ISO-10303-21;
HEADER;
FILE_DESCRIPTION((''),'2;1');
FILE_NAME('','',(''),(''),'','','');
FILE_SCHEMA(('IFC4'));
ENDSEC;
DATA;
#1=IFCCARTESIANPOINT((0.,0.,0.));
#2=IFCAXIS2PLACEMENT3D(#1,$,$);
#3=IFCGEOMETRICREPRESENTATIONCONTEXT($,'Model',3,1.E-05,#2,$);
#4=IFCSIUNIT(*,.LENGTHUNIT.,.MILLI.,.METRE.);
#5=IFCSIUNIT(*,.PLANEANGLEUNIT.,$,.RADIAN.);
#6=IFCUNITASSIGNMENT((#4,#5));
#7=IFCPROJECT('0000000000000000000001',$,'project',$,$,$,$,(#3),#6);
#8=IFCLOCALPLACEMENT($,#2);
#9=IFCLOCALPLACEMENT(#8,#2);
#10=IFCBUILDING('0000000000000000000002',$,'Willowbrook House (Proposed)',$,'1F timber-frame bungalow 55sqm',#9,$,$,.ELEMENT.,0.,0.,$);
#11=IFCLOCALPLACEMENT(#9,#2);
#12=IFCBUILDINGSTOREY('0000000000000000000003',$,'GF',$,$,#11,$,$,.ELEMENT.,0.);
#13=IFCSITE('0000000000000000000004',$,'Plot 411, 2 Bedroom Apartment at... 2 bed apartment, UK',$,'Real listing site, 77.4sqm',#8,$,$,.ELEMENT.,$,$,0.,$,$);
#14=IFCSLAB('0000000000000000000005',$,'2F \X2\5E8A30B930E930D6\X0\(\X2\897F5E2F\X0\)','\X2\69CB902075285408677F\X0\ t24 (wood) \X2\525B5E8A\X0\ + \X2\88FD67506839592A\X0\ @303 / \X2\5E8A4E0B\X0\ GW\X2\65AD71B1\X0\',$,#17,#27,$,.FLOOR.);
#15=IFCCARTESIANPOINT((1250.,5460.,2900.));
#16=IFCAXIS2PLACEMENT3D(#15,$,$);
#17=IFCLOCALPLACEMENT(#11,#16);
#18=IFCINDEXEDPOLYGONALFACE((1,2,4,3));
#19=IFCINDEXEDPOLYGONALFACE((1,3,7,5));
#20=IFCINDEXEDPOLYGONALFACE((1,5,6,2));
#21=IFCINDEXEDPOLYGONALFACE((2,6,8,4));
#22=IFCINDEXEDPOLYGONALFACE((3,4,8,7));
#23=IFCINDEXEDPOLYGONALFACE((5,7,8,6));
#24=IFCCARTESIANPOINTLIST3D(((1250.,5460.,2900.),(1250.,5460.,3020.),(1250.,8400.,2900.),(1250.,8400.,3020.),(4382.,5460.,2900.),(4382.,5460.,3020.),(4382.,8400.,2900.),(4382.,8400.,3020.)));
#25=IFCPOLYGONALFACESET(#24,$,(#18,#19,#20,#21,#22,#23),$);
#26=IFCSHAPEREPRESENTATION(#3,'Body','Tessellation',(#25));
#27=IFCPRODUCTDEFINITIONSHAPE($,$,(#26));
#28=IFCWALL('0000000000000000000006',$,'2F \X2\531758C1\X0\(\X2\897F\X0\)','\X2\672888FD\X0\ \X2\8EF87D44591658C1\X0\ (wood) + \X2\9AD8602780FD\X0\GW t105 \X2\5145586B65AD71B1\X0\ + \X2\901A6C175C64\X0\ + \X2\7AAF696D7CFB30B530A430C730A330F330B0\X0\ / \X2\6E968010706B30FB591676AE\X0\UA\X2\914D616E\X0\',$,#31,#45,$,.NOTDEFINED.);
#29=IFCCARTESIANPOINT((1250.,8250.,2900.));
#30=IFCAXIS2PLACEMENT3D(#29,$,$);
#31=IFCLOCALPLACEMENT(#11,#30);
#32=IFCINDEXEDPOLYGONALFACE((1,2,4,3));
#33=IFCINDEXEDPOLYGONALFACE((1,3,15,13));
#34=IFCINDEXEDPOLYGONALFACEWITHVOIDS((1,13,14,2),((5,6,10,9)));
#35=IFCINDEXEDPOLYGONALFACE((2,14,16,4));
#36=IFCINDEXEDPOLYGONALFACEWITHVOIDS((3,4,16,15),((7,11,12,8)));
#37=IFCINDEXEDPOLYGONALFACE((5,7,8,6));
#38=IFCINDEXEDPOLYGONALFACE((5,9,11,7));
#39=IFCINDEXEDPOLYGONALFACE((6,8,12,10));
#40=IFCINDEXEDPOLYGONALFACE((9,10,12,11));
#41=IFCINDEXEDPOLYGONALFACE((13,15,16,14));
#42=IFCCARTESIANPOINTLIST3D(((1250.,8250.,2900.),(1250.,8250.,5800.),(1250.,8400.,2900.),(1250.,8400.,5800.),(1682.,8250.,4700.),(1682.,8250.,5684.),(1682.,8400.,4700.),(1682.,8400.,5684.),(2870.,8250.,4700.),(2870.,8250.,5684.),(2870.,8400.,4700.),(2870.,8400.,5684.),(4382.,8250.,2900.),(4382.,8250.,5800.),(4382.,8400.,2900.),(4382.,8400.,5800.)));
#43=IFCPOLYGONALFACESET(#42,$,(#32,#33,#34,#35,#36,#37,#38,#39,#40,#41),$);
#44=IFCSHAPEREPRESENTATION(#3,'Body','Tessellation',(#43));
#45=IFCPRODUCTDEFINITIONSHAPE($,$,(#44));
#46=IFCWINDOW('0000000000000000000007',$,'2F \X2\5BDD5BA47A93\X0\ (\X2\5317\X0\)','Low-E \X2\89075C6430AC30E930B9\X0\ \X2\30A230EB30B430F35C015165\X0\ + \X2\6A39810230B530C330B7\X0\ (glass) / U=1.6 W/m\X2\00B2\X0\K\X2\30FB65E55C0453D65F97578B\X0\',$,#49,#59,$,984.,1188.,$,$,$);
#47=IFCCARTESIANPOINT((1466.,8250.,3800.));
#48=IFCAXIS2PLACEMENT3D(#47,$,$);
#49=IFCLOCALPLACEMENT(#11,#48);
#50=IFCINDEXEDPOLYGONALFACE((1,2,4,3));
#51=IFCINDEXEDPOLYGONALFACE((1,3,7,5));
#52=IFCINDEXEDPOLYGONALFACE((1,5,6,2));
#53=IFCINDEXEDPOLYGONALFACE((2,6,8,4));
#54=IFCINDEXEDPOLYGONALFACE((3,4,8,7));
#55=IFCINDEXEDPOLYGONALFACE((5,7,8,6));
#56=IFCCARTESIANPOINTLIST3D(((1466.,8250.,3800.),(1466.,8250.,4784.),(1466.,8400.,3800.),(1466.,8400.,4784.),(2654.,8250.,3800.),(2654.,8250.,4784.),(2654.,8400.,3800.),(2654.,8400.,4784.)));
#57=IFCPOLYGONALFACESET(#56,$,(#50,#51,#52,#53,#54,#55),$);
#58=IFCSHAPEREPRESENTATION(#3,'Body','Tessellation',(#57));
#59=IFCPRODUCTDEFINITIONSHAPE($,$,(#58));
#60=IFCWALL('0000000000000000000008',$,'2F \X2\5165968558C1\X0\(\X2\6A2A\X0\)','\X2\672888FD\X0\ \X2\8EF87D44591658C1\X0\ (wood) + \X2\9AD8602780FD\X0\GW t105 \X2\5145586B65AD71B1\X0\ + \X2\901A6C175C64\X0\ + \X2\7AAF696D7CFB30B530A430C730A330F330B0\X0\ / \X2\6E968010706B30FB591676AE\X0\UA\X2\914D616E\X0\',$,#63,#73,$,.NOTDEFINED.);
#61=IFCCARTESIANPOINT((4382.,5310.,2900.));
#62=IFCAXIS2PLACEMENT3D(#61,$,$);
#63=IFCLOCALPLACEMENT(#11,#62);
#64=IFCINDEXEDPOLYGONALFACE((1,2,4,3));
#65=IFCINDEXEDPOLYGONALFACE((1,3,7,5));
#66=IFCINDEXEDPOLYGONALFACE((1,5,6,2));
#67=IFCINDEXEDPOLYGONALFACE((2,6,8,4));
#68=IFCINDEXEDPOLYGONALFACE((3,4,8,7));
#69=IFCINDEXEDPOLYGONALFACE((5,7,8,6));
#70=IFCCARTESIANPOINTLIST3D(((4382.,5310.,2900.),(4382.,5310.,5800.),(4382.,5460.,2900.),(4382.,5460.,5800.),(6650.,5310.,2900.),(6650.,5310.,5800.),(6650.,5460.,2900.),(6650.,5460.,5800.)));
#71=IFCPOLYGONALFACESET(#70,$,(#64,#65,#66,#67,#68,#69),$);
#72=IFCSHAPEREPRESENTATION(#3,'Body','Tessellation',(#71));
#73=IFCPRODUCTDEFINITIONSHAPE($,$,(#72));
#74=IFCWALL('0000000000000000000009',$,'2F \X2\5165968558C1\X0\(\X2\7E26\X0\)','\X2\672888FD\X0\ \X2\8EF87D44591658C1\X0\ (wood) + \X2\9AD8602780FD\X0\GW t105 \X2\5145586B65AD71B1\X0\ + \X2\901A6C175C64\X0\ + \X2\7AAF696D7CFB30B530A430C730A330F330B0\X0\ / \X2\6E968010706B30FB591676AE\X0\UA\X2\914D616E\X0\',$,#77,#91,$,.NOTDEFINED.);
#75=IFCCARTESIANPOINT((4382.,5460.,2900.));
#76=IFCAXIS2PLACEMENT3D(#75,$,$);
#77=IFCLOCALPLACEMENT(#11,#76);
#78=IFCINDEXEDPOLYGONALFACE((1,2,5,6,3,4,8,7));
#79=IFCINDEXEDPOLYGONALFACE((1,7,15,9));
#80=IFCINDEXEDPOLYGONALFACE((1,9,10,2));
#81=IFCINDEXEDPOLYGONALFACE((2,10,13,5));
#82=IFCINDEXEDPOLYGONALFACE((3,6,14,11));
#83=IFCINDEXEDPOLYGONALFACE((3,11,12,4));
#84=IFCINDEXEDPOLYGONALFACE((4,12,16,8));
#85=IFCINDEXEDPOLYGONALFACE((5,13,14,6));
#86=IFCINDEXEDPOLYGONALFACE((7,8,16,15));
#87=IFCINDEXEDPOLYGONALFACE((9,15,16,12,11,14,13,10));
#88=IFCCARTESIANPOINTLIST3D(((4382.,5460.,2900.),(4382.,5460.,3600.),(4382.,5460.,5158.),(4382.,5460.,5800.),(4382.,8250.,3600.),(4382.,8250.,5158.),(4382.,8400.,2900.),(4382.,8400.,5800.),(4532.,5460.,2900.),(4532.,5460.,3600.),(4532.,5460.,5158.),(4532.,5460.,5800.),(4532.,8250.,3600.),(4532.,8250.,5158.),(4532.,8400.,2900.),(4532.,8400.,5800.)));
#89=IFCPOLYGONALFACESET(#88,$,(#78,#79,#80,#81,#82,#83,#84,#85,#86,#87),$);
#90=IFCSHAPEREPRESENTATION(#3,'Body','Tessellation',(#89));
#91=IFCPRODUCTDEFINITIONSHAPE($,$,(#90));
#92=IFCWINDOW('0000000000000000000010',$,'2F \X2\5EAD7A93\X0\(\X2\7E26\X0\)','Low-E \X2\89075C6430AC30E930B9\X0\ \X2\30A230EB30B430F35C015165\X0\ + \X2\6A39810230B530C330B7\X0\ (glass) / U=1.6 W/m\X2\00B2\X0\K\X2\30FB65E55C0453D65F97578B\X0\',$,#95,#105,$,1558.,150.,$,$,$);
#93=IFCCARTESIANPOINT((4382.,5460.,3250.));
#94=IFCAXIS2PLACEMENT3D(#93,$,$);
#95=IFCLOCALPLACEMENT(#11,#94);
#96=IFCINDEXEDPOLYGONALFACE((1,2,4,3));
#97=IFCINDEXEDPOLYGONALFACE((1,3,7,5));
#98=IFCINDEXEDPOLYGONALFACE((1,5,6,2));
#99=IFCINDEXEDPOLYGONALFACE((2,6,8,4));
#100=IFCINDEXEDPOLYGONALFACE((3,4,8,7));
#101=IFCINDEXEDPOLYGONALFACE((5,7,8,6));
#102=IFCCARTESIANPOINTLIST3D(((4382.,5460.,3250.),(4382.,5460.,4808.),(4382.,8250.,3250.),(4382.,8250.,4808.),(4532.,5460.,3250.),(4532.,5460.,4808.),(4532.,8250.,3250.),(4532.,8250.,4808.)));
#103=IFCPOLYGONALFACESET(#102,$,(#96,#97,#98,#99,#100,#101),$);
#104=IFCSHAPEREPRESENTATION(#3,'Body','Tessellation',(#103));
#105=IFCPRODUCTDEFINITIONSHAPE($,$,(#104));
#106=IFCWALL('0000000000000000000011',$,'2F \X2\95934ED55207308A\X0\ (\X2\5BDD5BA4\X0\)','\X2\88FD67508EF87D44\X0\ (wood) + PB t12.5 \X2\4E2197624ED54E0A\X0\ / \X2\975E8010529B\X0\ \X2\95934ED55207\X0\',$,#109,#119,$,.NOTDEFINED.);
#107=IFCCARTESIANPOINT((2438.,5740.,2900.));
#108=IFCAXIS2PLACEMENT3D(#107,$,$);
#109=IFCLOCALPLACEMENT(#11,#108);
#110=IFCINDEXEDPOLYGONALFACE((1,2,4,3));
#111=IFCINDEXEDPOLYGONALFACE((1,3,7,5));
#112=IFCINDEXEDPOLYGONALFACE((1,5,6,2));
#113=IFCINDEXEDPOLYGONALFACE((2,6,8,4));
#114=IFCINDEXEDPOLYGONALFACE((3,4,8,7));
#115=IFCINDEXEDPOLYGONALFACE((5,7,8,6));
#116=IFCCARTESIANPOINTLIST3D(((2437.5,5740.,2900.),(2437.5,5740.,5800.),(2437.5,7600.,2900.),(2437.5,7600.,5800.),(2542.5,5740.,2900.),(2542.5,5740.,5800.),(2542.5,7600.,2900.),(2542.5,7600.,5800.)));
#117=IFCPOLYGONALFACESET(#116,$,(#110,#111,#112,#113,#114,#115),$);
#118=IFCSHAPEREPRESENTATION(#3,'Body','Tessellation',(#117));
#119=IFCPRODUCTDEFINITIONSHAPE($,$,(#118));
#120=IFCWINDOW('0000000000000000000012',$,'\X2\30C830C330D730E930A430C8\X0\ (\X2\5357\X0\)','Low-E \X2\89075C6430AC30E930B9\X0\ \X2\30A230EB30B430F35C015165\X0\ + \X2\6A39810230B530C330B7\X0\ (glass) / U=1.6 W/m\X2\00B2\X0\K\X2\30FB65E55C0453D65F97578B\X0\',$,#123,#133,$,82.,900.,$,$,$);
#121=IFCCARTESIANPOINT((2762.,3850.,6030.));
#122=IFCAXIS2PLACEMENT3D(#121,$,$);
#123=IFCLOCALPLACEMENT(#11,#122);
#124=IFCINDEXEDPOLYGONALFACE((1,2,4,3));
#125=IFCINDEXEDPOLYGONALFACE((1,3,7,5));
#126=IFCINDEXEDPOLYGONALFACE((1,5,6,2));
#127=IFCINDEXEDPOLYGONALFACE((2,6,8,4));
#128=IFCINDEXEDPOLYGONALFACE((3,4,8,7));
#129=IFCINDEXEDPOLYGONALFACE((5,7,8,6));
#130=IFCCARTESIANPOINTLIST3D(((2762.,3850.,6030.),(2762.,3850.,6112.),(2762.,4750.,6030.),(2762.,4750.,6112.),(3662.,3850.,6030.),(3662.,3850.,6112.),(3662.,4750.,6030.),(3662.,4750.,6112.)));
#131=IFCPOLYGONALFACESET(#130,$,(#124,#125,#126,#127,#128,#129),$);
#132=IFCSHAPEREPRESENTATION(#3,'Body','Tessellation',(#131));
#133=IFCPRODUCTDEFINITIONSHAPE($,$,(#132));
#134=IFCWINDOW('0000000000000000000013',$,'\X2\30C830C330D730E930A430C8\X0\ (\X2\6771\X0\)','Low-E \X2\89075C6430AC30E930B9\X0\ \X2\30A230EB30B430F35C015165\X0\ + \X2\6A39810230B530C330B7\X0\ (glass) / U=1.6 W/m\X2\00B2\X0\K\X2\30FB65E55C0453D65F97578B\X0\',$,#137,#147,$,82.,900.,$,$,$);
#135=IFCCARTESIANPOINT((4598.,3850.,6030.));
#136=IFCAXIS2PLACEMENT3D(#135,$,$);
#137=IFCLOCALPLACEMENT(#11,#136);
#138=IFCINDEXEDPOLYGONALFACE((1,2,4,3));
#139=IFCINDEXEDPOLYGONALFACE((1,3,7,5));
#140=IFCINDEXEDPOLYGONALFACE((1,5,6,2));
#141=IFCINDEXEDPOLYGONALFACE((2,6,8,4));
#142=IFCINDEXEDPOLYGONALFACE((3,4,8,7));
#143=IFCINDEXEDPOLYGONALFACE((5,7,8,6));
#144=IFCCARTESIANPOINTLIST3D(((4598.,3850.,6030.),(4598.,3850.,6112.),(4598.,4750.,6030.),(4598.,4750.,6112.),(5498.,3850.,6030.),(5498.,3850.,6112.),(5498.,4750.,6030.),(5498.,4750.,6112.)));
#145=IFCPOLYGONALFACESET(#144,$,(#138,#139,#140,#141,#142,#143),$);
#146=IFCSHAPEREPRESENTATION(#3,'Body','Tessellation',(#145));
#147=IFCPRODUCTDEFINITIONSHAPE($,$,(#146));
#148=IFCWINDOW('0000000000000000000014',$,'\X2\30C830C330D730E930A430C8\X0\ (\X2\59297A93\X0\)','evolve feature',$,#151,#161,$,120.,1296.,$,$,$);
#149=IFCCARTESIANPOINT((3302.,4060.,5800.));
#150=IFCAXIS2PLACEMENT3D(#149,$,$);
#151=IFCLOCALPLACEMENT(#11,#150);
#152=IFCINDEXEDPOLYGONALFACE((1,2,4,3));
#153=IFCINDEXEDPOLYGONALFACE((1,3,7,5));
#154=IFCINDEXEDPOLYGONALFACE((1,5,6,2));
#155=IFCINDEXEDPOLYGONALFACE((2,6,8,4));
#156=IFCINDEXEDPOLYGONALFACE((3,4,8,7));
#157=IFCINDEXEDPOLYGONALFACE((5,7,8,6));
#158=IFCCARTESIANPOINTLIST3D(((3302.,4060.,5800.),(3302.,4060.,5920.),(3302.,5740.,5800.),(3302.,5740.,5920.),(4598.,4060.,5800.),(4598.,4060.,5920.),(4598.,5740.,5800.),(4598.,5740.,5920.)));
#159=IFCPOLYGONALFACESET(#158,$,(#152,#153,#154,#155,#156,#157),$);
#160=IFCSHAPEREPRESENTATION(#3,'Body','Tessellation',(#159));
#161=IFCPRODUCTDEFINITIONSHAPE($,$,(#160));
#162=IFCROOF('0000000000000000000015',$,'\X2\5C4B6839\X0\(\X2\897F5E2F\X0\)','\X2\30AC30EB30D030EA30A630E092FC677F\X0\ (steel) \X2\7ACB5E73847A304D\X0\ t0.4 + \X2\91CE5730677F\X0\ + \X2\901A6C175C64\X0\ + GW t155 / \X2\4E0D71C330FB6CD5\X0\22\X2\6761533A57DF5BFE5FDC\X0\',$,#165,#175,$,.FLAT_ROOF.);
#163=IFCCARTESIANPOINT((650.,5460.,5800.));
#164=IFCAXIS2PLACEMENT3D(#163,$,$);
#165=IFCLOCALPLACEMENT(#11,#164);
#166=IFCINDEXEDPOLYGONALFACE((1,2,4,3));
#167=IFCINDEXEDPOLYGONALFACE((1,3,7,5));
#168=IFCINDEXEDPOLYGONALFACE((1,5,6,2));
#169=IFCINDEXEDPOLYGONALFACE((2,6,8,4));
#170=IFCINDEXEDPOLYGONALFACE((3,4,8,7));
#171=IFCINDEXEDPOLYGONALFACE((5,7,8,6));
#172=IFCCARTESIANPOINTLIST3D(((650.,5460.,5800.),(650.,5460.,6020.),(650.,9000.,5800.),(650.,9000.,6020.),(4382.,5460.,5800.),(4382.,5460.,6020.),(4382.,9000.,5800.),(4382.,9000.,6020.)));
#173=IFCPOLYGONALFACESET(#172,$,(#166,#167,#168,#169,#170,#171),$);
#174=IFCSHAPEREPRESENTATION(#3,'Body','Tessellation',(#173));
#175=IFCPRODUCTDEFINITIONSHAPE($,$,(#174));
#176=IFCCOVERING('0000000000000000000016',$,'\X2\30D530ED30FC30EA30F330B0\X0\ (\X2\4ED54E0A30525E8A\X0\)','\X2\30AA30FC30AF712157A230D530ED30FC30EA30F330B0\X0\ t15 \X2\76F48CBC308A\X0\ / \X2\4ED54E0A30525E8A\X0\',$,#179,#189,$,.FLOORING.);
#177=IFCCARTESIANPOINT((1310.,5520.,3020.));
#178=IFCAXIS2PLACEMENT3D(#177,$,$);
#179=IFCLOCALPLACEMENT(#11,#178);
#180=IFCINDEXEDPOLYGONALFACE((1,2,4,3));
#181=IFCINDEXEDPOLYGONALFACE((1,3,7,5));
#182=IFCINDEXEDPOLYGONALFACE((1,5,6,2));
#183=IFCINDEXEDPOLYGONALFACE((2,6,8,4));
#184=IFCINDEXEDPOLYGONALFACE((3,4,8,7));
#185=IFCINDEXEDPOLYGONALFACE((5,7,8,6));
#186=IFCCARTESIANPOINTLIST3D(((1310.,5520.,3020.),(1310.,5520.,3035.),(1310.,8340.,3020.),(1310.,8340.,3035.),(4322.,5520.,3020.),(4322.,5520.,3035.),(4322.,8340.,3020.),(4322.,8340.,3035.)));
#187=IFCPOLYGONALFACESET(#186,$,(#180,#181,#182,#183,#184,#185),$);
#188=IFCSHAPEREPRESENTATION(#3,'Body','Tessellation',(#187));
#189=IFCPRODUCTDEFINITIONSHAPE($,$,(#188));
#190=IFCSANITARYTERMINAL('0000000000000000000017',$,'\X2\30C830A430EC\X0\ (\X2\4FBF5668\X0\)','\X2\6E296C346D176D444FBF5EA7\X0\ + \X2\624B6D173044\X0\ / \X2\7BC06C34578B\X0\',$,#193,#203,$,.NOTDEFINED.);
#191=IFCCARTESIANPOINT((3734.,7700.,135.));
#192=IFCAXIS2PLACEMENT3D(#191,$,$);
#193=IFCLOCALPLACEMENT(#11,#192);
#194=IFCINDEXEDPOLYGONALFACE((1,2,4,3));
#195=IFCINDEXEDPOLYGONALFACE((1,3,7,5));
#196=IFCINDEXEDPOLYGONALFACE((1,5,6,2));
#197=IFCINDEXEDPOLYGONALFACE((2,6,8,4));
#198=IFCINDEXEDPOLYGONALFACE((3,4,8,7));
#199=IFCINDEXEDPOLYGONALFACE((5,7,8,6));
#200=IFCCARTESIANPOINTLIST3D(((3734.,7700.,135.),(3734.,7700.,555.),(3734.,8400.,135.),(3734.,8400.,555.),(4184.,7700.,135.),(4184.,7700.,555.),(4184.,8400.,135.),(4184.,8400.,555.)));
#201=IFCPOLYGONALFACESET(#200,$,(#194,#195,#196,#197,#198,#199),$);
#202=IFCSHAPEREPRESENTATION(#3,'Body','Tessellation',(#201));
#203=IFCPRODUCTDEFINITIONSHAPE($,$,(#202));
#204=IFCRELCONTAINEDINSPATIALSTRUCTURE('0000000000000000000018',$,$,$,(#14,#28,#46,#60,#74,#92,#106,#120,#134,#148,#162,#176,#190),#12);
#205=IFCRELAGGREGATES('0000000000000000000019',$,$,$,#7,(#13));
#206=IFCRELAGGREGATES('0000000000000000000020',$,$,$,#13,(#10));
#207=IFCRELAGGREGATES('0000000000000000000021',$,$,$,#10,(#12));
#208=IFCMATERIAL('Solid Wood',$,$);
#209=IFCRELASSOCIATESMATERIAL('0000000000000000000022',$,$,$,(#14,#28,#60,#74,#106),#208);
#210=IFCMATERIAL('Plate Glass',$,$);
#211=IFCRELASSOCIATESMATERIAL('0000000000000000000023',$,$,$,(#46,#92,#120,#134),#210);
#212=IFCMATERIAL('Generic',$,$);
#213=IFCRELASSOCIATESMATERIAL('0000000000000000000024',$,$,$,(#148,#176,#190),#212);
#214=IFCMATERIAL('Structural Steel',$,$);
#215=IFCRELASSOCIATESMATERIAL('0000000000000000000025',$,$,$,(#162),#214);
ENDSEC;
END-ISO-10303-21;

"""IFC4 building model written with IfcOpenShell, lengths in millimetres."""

from ifc_helpers import new_model, si_unit, frame, frame_2d, origin, place, context, project, spatial, rectangle, extrude, material, element, fill, save


model = new_model("IFC4")

# Units and contexts
model_context = context("Model", 3, precision=1e-05, world=origin())
ifc_project = project(units=[si_unit("LENGTHUNIT", "METRE", prefix="MILLI"), si_unit("PLANEANGLEUNIT", "RADIAN")], contexts=[model_context])

# Site, building, storey
site_placement = place(None, origin())
site = spatial("IfcSite", under=ifc_project, at=site_placement, Name="Plot 411, 2 Bedroom Apartment at... 2 bed apartment, UK", ObjectType="Real listing site, 77.4sqm", CompositionType="ELEMENT", RefElevation=0.0)
building_placement = place(site_placement, origin())
building = spatial("IfcBuilding", under=site, at=building_placement, Name="Willowbrook House (Proposed)", ObjectType="1F timber-frame bungalow 55sqm", CompositionType="ELEMENT", ElevationOfRefHeight=0.0, ElevationOfTerrain=0.0)
storey_placement = place(building_placement, origin())
storey = spatial("IfcBuildingStorey", under=building, at=storey_placement, Name="GF", CompositionType="ELEMENT", Elevation=0.0)

# Slab
ifc_material_1 = material(Name="Solid Wood")
slab_placement = place(storey_placement, frame((1250.0, 5460.0, 2900.0)))
element("IfcSlab", 1, at=slab_placement, inside=storey, material=ifc_material_1, Name="2F 床スラブ(西帯)", Description="構造用合板 t24 (wood) 剛床 + 製材根太 @303 / 床下 GW断熱", PredefinedType="FLOOR", context=model_context, shape_type="SweptSolid", body=[
    extrude(rectangle(XDim=3132.0, YDim=2940.0, at=frame_2d((1566.0, 1470.0))), frame((1250.0, 5460.0, 2900.0)), (0.0, 0.0, 1.0), 120.0),
])

# Wall, opening, window
wall_1_placement = place(storey_placement, frame((1250.0, 8250.0, 2900.0)))
wall_1 = element("IfcWall", 2, at=wall_1_placement, inside=storey, material=ifc_material_1, Name="2F 北壁(西)", Description="木製 軸組外壁 (wood) + 高性能GW t105 充填断熱 + 通気層 + 窯業系サイディング / 準耐火・外皮UA配慮", PredefinedType="NOTDEFINED", context=model_context, shape_type="SweptSolid", body=[
    extrude(rectangle(XDim=3132.0, YDim=150.0, at=frame_2d((1566.0, 75.0))), frame((1250.0, 8250.0, 2900.0)), (0.0, 0.0, 1.0), 2900.0),
])
opening_1_placement = place(storey_placement, frame((1466.0, 8250.0, 3800.0)))
opening_1 = element("IfcOpeningElement", 3, at=opening_1_placement, cuts=wall_1, PredefinedType="NOTDEFINED", context=model_context, shape_type="SweptSolid", body=[
    extrude(rectangle(XDim=1188.0, YDim=150.0, at=frame_2d((594.0, 75.0))), frame((1466.0, 8250.0, 3800.0)), (0.0, 0.0, 1.0), 984.0),
])
ifc_material_2 = material(Name="Plate Glass")
window_1_placement = place(storey_placement, frame((1466.0, 8250.0, 3800.0)))
window_1 = element("IfcWindow", 4, at=window_1_placement, inside=storey, material=ifc_material_2, Name="2F 寝室窓 (北)", Description="Low-E 複層ガラス アルゴン封入 + 樹脂サッシ (glass) / U=1.6 W/m²K・日射取得型", OverallHeight=984.0, OverallWidth=1188.0, context=model_context, shape_type="SweptSolid", body=[
    extrude(rectangle(XDim=1188.0, YDim=150.0, at=frame_2d((594.0, 75.0))), frame((1466.0, 8250.0, 3800.0)), (0.0, 0.0, 1.0), 984.0),
])
fill(opening_1, window_1)

# Wall
wall_2_placement = place(storey_placement, frame((4382.0, 5310.0, 2900.0)))
element("IfcWall", 5, at=wall_2_placement, inside=storey, material=ifc_material_1, Name="2F 入隅壁(横)", Description="木製 軸組外壁 (wood) + 高性能GW t105 充填断熱 + 通気層 + 窯業系サイディング / 準耐火・外皮UA配慮", PredefinedType="NOTDEFINED", context=model_context, shape_type="SweptSolid", body=[
    extrude(rectangle(XDim=2268.0, YDim=150.0, at=frame_2d((1134.0, 75.0))), frame((4382.0, 5310.0, 2900.0)), (0.0, 0.0, 1.0), 2900.0),
])

# Wall, opening, window
wall_3_placement = place(storey_placement, frame((4382.0, 5460.0, 2900.0)))
wall_3 = element("IfcWall", 6, at=wall_3_placement, inside=storey, material=ifc_material_1, Name="2F 入隅壁(縦)", Description="木製 軸組外壁 (wood) + 高性能GW t105 充填断熱 + 通気層 + 窯業系サイディング / 準耐火・外皮UA配慮", PredefinedType="NOTDEFINED", context=model_context, shape_type="SweptSolid", body=[
    extrude(rectangle(XDim=150.0, YDim=2940.0, at=frame_2d((75.0, 1470.0))), frame((4382.0, 5460.0, 2900.0)), (0.0, 0.0, 1.0), 2900.0),
])
opening_2_placement = place(storey_placement, frame((4382.0, 5460.0, 3250.0)))
opening_2 = element("IfcOpeningElement", 7, at=opening_2_placement, cuts=wall_3, PredefinedType="NOTDEFINED", context=model_context, shape_type="SweptSolid", body=[
    extrude(rectangle(XDim=150.0, YDim=2790.0, at=frame_2d((75.0, 1395.0))), frame((4382.0, 5460.0, 3250.0)), (0.0, 0.0, 1.0), 1558.0),
])
window_2_placement = place(storey_placement, frame((4382.0, 5460.0, 3250.0)))
window_2 = element("IfcWindow", 8, at=window_2_placement, inside=storey, material=ifc_material_2, Name="2F 庭窓(縦)", Description="Low-E 複層ガラス アルゴン封入 + 樹脂サッシ (glass) / U=1.6 W/m²K・日射取得型", OverallHeight=1558.0, OverallWidth=150.0, context=model_context, shape_type="SweptSolid", body=[
    extrude(rectangle(XDim=150.0, YDim=2790.0, at=frame_2d((75.0, 1395.0))), frame((4382.0, 5460.0, 3250.0)), (0.0, 0.0, 1.0), 1558.0),
])
fill(opening_2, window_2)

# Wall
wall_4_placement = place(storey_placement, frame((2438.0, 5740.0, 2900.0)))
element("IfcWall", 9, at=wall_4_placement, inside=storey, material=ifc_material_1, Name="2F 間仕切り (寝室)", Description="製材軸組 (wood) + PB t12.5 両面仕上 / 非耐力 間仕切", PredefinedType="NOTDEFINED", context=model_context, shape_type="SweptSolid", body=[
    extrude(rectangle(XDim=105.0, YDim=1860.0, at=frame_2d((52.0, 930.0))), frame((2438.0, 5740.0, 2900.0)), (0.0, 0.0, 1.0), 2900.0),
])

# Windows
window_3_placement = place(storey_placement, frame((2762.0, 3850.0, 6030.0)))
element("IfcWindow", 10, at=window_3_placement, inside=storey, material=ifc_material_2, Name="トップライト (南)", Description="Low-E 複層ガラス アルゴン封入 + 樹脂サッシ (glass) / U=1.6 W/m²K・日射取得型", OverallHeight=82.0, OverallWidth=900.0, context=model_context, shape_type="SweptSolid", body=[
    extrude(rectangle(XDim=900.0, YDim=900.0, at=frame_2d((450.0, 450.0))), frame((2762.0, 3850.0, 6030.0)), (0.0, 0.0, 1.0), 82.0),
])
window_4_placement = place(storey_placement, frame((4598.0, 3850.0, 6030.0)))
element("IfcWindow", 11, at=window_4_placement, inside=storey, material=ifc_material_2, Name="トップライト (東)", Description="Low-E 複層ガラス アルゴン封入 + 樹脂サッシ (glass) / U=1.6 W/m²K・日射取得型", OverallHeight=82.0, OverallWidth=900.0, context=model_context, shape_type="SweptSolid", body=[
    extrude(rectangle(XDim=900.0, YDim=900.0, at=frame_2d((450.0, 450.0))), frame((4598.0, 3850.0, 6030.0)), (0.0, 0.0, 1.0), 82.0),
])
ifc_material_3 = material(Name="Generic")
window_5_placement = place(storey_placement, frame((3302.0, 4060.0, 5800.0)))
element("IfcWindow", 12, at=window_5_placement, inside=storey, material=ifc_material_3, Name="トップライト (天窓)", Description="evolve feature", OverallHeight=120.0, OverallWidth=1296.0, context=model_context, shape_type="SweptSolid", body=[
    extrude(rectangle(XDim=1296.0, YDim=1680.0, at=frame_2d((648.0, 840.0))), frame((3302.0, 4060.0, 5800.0)), (0.0, 0.0, 1.0), 120.0),
])

# Roof
ifc_material_4 = material(Name="Structural Steel")
for number, where, name in (
    (13, (650.0, 5460.0, 5800.0), "屋根(西帯)"),
):
    element("IfcRoof", number, at=place(storey_placement, frame(where)), inside=storey, material=ifc_material_4, Name=name, Description="ガルバリウム鋼板 (steel) 立平葺き t0.4 + 野地板 + 通気層 + GW t155 / 不燃・法22条区域対応", PredefinedType="FLAT_ROOF", context=model_context, shape_type="SweptSolid", body=[
        extrude(rectangle(XDim=3732.0, YDim=3540.0, at=frame_2d((1866.0, 1770.0))), frame((650.0, 5460.0, 5800.0)), (0.0, 0.0, 1.0), 220.0),
    ])

# Covering
covering_placement = place(storey_placement, frame((1310.0, 5520.0, 3020.0)))
element("IfcCovering", 14, at=covering_placement, inside=storey, material=ifc_material_3, Name="フローリング (仕上げ床)", Description="オーク無垢フローリング t15 直貼り / 仕上げ床", PredefinedType="FLOORING", context=model_context, shape_type="SweptSolid", body=[
    extrude(rectangle(XDim=3012.0, YDim=2820.0, at=frame_2d((1506.0, 1410.0))), frame((1310.0, 5520.0, 3020.0)), (0.0, 0.0, 1.0), 15.0),
])

# Sanitary terminal
sanitary_terminal_placement = place(storey_placement, frame((3734.0, 7700.0, 135.0)))
element("IfcSanitaryTerminal", 15, at=sanitary_terminal_placement, inside=storey, material=ifc_material_3, Name="トイレ (便器)", Description="温水洗浄便座 + 手洗い / 節水型", PredefinedType="NOTDEFINED", context=model_context, shape_type="SweptSolid", body=[
    extrude(rectangle(XDim=450.0, YDim=700.0, at=frame_2d((225.0, 350.0))), frame((3734.0, 7700.0, 135.0)), (0.0, 0.0, 1.0), 420.0),
])

save(model, "model.ifc")
